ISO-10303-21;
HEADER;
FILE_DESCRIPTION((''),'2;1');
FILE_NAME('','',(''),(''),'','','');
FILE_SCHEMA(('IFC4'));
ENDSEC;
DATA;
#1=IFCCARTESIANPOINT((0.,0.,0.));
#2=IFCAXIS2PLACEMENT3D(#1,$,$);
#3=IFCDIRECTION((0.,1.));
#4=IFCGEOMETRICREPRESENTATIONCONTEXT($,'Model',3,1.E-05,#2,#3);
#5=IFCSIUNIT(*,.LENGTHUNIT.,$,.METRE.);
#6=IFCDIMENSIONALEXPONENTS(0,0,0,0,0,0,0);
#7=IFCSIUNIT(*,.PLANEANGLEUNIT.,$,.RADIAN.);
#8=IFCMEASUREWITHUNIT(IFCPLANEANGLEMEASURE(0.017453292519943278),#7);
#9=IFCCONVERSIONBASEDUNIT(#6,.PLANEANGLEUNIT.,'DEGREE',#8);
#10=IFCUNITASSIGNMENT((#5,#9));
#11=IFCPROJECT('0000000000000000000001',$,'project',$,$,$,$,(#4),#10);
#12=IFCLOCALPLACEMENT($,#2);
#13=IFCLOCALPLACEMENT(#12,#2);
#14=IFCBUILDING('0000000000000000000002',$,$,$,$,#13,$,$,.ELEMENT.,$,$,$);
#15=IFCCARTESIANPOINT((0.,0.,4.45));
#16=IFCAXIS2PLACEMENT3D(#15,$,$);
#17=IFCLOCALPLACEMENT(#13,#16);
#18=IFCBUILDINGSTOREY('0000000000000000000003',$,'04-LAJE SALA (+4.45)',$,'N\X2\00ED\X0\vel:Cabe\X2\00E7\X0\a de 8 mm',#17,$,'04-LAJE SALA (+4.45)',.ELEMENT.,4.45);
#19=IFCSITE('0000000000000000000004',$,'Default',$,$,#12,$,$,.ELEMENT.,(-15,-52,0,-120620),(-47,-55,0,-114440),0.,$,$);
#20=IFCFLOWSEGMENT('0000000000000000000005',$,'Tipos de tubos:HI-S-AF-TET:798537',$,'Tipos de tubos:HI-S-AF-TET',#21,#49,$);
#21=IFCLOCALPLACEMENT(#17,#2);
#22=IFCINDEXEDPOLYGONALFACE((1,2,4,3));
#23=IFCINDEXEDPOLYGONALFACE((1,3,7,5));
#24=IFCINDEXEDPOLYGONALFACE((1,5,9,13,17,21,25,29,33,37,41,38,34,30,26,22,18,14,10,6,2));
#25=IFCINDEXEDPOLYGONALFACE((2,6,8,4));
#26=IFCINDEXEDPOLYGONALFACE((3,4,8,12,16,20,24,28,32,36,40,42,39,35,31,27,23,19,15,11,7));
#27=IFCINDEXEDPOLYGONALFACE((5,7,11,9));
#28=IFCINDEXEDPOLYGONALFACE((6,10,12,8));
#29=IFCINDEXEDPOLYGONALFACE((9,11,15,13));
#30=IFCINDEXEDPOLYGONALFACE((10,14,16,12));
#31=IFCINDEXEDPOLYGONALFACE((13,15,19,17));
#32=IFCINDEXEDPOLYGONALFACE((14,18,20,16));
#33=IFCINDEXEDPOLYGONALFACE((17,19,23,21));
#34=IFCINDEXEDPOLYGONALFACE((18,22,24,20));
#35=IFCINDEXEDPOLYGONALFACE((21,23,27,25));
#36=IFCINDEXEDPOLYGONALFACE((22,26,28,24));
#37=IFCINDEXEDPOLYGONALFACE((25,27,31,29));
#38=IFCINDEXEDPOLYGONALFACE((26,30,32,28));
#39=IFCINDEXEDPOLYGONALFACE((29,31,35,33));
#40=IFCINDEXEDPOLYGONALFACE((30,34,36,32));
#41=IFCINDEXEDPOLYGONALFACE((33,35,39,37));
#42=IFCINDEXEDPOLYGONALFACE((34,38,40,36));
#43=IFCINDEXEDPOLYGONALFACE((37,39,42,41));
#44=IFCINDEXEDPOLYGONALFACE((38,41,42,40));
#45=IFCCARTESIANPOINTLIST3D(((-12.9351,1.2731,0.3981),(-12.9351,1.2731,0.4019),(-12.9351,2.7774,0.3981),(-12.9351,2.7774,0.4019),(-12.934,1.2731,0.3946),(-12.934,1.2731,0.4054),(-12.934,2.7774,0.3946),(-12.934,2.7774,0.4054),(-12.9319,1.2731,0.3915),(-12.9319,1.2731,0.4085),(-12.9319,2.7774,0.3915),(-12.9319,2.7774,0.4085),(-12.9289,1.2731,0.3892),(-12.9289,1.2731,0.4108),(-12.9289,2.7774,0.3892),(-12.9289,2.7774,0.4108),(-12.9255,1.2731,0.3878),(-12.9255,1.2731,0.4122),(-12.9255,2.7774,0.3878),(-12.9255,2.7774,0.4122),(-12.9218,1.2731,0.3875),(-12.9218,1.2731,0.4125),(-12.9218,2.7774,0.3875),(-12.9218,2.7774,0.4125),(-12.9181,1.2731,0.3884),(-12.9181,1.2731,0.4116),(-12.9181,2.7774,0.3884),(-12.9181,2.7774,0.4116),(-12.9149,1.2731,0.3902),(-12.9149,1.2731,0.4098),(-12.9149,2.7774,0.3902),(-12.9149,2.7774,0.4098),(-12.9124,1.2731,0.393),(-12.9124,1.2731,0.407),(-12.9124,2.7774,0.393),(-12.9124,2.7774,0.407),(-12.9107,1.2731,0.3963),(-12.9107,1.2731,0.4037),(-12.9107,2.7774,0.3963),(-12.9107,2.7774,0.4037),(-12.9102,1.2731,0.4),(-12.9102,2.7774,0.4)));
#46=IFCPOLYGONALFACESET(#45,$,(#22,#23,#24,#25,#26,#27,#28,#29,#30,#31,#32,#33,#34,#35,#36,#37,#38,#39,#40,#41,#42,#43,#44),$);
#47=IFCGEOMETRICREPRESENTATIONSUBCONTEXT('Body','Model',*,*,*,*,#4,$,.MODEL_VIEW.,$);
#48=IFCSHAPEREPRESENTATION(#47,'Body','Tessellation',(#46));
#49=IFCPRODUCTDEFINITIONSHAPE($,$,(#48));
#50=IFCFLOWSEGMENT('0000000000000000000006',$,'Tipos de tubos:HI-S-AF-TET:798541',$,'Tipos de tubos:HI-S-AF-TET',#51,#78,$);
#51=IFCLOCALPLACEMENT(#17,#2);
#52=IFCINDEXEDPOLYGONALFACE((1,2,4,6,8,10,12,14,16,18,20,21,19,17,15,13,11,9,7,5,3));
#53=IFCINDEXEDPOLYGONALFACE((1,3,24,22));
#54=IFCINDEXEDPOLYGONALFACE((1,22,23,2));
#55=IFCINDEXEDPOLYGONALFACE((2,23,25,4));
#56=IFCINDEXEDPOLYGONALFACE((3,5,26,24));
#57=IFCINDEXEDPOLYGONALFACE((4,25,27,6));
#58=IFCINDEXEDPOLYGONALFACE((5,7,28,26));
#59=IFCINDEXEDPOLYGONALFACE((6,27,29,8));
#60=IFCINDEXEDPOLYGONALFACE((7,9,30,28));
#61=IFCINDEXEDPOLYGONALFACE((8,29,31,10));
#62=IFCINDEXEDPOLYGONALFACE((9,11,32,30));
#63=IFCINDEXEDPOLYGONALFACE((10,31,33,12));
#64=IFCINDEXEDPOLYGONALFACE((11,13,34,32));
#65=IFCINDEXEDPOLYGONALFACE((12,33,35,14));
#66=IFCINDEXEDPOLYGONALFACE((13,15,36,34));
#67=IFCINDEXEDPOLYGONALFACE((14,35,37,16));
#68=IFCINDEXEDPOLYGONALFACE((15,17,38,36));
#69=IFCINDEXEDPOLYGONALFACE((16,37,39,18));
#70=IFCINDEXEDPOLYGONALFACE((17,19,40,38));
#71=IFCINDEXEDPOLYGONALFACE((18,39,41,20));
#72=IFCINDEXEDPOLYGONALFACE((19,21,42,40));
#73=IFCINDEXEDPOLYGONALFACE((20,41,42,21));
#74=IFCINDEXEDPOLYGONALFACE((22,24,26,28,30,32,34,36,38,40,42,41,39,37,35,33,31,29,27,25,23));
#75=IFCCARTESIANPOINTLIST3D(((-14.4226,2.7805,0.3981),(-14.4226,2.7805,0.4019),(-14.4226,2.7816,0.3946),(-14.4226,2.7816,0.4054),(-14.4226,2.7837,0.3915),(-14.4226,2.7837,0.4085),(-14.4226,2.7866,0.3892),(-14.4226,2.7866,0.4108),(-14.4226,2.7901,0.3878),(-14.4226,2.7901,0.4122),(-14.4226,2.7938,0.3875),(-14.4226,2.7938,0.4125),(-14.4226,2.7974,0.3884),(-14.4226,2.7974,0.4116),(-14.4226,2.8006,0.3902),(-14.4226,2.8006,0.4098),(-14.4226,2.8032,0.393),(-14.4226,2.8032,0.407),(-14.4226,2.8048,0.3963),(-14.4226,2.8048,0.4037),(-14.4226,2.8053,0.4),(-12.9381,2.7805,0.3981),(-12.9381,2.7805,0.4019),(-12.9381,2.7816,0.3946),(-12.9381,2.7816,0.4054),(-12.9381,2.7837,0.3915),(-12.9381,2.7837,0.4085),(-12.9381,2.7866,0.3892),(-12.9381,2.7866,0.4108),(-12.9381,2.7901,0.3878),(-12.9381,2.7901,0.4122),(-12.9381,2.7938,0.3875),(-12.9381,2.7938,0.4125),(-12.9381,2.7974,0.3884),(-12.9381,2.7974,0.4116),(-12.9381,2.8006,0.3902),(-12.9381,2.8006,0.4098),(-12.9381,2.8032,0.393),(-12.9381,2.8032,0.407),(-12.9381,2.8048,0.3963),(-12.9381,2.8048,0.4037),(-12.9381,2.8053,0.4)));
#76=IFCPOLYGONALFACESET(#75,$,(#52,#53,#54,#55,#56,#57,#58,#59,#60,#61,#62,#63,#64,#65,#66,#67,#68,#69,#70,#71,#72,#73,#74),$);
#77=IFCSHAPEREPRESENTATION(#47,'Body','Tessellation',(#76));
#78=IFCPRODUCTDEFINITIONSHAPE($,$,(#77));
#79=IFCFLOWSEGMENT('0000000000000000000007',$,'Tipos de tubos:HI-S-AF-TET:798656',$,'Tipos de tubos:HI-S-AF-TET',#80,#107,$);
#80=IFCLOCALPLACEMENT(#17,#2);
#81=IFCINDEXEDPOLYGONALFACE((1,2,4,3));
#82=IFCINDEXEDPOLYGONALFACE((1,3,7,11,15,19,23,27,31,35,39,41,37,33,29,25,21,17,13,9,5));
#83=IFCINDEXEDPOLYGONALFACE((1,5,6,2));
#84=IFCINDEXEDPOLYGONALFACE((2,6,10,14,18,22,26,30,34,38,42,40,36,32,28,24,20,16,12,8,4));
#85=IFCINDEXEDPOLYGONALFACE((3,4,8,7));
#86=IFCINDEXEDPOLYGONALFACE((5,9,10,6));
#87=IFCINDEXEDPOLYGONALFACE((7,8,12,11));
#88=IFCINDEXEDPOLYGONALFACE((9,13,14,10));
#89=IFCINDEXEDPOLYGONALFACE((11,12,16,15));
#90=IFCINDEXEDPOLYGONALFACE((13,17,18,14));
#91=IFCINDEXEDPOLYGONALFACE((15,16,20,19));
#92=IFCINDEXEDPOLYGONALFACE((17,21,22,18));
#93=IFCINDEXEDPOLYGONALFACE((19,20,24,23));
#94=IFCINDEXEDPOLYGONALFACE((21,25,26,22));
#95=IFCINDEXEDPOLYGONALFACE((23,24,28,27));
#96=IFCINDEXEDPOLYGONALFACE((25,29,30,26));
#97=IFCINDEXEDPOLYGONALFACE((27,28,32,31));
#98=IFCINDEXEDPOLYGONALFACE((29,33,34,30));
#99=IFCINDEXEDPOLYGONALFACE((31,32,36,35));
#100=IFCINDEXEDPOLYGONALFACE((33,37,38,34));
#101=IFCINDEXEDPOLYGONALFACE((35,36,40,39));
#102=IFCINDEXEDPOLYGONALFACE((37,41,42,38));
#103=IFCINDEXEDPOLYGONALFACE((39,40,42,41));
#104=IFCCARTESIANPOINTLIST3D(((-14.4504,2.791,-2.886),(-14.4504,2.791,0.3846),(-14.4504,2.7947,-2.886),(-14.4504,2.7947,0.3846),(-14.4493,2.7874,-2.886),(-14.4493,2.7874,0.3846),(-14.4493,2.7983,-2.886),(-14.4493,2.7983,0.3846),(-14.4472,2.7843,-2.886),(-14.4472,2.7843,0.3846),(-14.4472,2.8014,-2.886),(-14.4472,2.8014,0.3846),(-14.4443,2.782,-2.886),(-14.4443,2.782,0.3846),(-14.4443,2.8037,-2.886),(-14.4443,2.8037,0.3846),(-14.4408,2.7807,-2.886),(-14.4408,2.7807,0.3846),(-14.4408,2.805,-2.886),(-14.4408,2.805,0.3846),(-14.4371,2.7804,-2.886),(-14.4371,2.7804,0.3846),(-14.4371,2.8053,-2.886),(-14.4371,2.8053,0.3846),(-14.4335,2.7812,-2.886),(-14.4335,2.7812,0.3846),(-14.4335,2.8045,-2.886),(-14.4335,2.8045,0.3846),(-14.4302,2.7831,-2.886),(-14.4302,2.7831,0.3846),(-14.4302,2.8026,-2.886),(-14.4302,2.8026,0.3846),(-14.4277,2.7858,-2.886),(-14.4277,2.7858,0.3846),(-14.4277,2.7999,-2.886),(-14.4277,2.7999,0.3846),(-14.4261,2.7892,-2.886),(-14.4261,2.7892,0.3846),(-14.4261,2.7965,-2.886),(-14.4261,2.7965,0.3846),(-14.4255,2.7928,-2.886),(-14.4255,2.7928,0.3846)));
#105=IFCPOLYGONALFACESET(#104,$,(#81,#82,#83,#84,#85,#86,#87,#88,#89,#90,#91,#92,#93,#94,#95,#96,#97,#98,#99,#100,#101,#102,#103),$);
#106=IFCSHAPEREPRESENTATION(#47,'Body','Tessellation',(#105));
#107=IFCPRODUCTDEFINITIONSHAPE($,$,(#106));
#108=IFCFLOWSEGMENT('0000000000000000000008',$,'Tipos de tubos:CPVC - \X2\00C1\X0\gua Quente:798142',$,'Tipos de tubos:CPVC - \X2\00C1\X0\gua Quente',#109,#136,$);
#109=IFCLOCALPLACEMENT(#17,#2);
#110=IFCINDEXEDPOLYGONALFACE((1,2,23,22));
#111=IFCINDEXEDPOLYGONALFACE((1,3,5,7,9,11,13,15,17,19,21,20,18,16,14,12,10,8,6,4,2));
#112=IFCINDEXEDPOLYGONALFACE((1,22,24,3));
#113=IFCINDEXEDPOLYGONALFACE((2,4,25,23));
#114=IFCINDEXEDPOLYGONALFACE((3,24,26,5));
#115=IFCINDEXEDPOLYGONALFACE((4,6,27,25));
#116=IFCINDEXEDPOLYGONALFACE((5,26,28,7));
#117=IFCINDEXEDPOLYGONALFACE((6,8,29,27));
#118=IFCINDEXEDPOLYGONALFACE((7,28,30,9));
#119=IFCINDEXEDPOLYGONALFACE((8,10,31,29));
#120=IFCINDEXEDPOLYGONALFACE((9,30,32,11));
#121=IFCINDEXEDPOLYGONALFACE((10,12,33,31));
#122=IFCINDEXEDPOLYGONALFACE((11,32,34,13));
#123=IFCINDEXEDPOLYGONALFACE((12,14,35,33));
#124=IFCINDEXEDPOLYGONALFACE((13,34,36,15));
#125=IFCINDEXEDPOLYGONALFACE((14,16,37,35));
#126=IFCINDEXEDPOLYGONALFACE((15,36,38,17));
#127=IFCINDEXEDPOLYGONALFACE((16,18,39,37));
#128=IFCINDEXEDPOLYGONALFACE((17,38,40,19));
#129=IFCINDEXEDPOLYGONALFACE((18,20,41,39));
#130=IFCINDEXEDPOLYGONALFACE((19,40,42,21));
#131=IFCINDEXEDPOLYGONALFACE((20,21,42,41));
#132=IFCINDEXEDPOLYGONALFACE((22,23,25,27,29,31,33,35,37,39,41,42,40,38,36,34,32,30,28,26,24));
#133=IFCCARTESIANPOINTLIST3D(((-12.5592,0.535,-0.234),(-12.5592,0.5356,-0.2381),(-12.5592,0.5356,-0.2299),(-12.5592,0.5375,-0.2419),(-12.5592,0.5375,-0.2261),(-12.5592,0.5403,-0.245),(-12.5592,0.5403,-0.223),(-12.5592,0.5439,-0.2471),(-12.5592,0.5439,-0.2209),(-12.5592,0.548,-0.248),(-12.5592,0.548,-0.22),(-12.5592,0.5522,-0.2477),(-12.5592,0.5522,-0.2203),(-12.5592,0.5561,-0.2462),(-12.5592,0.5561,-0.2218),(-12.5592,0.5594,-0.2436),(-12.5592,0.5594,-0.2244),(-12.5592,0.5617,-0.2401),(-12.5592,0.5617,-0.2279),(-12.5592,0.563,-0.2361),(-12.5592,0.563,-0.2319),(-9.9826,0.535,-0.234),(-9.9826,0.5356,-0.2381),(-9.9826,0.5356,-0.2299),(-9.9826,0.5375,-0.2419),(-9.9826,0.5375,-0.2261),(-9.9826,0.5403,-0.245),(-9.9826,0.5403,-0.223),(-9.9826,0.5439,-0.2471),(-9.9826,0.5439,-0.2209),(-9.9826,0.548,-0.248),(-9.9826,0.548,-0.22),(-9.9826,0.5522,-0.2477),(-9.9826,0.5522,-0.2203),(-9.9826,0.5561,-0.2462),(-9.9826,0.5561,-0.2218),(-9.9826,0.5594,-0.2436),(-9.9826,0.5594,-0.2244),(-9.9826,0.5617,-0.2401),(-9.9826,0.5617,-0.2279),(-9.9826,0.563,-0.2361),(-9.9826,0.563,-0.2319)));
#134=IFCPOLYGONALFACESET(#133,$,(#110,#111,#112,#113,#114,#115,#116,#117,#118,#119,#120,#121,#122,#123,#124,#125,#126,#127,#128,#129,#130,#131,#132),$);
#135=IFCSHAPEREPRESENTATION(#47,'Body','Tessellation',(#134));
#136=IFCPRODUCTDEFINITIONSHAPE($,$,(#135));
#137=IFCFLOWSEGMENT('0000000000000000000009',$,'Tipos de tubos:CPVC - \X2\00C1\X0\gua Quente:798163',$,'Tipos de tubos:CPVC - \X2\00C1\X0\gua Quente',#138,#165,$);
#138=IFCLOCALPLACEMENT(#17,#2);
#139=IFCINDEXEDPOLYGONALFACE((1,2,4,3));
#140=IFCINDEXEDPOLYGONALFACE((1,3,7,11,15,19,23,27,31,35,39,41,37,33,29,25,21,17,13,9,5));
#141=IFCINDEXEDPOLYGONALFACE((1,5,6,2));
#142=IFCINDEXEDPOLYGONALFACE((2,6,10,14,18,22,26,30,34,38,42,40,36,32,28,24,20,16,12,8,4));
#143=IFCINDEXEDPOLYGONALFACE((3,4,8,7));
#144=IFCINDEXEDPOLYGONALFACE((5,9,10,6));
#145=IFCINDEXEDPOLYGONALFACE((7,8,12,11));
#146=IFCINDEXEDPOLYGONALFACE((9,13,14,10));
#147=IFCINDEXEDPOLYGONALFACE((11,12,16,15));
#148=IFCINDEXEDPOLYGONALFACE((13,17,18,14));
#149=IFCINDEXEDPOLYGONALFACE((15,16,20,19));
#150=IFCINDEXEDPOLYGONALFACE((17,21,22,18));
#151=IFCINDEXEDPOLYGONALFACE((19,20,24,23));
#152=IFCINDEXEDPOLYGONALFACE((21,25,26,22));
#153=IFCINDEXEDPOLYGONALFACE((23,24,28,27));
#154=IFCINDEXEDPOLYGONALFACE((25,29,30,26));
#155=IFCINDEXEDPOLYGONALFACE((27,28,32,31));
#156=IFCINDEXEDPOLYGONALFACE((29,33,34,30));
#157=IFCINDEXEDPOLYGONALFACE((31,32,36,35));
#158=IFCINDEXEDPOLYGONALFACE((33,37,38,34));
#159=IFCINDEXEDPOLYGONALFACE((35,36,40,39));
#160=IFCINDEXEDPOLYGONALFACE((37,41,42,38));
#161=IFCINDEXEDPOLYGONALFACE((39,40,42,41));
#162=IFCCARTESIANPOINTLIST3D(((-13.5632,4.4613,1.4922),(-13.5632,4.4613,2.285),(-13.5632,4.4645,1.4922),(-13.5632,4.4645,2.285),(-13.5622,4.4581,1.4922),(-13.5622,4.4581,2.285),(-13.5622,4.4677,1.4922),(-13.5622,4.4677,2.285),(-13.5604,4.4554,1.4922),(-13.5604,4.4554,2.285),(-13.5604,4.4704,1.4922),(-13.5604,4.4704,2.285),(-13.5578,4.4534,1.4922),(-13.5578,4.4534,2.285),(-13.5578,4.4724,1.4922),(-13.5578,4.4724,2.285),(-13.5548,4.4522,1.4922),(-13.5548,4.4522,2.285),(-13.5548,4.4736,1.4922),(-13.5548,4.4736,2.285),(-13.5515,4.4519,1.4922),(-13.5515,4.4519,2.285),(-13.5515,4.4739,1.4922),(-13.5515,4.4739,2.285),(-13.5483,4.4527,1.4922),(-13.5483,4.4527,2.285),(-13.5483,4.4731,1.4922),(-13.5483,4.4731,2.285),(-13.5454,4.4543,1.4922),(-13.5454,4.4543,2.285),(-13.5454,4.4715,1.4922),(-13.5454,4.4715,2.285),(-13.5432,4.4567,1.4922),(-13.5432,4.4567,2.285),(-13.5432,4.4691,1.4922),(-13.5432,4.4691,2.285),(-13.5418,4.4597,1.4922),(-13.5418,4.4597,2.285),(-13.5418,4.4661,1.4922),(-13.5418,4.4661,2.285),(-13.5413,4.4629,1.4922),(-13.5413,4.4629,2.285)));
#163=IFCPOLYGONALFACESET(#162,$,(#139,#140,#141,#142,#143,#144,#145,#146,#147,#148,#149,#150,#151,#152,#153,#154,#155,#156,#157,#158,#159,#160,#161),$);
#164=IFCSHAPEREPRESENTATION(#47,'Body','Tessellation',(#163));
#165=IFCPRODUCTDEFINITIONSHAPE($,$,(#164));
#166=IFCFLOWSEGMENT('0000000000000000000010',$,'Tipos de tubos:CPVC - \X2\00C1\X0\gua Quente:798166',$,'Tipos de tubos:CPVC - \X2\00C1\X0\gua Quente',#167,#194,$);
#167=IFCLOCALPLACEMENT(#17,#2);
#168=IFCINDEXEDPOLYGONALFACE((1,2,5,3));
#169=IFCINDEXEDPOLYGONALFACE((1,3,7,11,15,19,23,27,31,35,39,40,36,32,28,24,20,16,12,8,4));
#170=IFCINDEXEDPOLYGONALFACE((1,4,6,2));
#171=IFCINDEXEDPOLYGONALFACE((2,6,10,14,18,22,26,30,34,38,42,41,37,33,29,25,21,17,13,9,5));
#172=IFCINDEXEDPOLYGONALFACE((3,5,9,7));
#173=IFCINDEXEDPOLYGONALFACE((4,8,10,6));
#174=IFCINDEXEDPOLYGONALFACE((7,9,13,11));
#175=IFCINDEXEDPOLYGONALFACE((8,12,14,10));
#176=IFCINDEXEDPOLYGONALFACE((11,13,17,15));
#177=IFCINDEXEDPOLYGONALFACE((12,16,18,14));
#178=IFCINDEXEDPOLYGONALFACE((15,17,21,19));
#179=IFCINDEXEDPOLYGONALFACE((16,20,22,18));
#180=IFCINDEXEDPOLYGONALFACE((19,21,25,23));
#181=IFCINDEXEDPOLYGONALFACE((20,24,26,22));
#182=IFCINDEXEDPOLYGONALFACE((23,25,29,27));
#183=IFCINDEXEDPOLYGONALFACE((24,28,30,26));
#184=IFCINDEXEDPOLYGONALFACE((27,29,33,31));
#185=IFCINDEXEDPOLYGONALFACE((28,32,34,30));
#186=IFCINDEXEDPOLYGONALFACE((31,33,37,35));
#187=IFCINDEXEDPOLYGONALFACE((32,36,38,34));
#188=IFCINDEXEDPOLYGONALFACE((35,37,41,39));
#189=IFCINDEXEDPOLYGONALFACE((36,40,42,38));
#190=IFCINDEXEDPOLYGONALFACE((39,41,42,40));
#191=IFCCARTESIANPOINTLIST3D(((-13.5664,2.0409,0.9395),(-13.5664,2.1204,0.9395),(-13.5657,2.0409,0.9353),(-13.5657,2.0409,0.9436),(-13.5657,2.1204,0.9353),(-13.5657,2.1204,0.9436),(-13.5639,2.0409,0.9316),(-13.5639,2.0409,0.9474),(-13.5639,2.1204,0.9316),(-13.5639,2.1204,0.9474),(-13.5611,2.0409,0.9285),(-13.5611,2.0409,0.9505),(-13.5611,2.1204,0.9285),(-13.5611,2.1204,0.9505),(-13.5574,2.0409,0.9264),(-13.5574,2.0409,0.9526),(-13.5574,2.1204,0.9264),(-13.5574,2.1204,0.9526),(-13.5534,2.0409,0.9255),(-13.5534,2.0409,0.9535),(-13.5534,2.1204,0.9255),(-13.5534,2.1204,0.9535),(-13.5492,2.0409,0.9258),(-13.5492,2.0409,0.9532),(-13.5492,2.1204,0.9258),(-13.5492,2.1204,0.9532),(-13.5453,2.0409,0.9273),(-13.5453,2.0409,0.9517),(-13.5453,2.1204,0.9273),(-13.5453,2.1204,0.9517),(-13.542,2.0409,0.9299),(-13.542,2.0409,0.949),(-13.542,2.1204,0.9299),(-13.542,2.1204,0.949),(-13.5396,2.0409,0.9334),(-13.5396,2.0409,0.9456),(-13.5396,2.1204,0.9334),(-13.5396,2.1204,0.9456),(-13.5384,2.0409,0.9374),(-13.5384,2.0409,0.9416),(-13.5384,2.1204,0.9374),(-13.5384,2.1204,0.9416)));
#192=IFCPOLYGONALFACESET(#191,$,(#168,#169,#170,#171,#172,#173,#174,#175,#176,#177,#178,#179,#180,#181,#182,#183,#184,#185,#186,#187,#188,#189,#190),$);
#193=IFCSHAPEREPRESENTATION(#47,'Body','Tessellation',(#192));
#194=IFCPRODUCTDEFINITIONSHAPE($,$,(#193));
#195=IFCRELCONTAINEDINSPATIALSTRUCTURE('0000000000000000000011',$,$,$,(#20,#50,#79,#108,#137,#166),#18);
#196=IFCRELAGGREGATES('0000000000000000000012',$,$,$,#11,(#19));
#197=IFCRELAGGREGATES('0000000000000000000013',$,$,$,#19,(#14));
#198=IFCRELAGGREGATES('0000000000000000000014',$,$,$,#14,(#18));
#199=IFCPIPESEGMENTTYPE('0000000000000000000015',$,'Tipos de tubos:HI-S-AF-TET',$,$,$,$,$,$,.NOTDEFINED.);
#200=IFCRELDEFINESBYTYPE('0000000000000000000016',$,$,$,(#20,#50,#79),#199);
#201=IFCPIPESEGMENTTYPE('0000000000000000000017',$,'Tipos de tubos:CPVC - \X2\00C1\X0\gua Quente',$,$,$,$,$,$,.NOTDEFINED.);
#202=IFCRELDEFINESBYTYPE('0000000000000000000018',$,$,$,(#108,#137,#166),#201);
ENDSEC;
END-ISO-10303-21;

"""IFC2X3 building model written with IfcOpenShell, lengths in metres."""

from ifc_helpers import new_model, entity, si_unit, converted_unit, direction, frame, frame_2d, origin, origin_2d_with_axis, place, context, subcontext, project, spatial, circle, extrude, type_object, element, save


model = new_model("IFC2X3")

# Units and contexts
model_context = context("Model", 3, precision=1e-05, world=origin(), true_north=direction((0.0, 1.0)))
body_context = subcontext(model_context, "Body", "Model", "MODEL_VIEW")
ifc_project = project(units=[si_unit("LENGTHUNIT", "METRE"), converted_unit("PLANEANGLEUNIT", "DEGREE", entity("IfcPlaneAngleMeasure", 0.017453292519943278), si_unit("PLANEANGLEUNIT", "RADIAN"), dimensions=[0, 0, 0, 0, 0, 0, 0])], contexts=[model_context])

# Site, building, storey
site_placement = place(None, origin())
site = spatial("IfcSite", under=ifc_project, at=site_placement, Name="Default", CompositionType="ELEMENT", RefLatitude=(-15, -52, 0, -120620), RefLongitude=(-47, -55, 0, -114440), RefElevation=0.0)
building_placement = place(site_placement, origin())
building = spatial("IfcBuilding", under=site, at=building_placement, CompositionType="ELEMENT")
storey_placement = place(building_placement, frame((0.0, 0.0, 4.45)))
storey = spatial("IfcBuildingStorey", under=building, at=storey_placement, Name="04-LAJE SALA (+4.45)", ObjectType="Nível:Cabeça de 8 mm", LongName="04-LAJE SALA (+4.45)", CompositionType="ELEMENT", Elevation=4.45)

# Flow segments
pipe_segment_type_1 = type_object("IfcPipeSegmentType", Name="Tipos de tubos:HI-S-AF-TET", PredefinedType="NOTDEFINED")
flow_segment_1_placement = place(storey_placement, origin())
element("IfcFlowSegment", 1, at=flow_segment_1_placement, inside=storey, type_object=pipe_segment_type_1, Name="Tipos de tubos:HI-S-AF-TET:798537", ObjectType="Tipos de tubos:HI-S-AF-TET", context=body_context, shape_type="SweptSolid", body=[
    extrude(circle(Radius=0.0125, at=frame_2d((0.0, 0.0), x_axis=(1.0, 0.0))), frame((-12.9227, 1.2731, 0.4), z_axis=(0.0, 1.0, 0.0), x_axis=(1.0, 0.0, 0.0)), (0.0, 0.0, 1.0), 1.5044),
])
flow_segment_2_placement = place(storey_placement, origin())
element("IfcFlowSegment", 2, at=flow_segment_2_placement, inside=storey, type_object=pipe_segment_type_1, Name="Tipos de tubos:HI-S-AF-TET:798541", ObjectType="Tipos de tubos:HI-S-AF-TET", context=body_context, shape_type="SweptSolid", body=[
    extrude(circle(Radius=0.0125, at=origin_2d_with_axis()), frame((-14.4226, 2.7928, 0.4), z_axis=(1.0, 0.0, 0.0), x_axis=(0.0, 1.0, 0.0)), (0.0, 0.0, 1.0), 1.4845),
])
flow_segment_3_placement = place(storey_placement, origin())
element("IfcFlowSegment", 3, at=flow_segment_3_placement, inside=storey, type_object=pipe_segment_type_1, Name="Tipos de tubos:HI-S-AF-TET:798656", ObjectType="Tipos de tubos:HI-S-AF-TET", context=body_context, shape_type="SweptSolid", body=[
    extrude(circle(Radius=0.0125, at=origin_2d_with_axis()), frame((-14.438, 2.7928, -2.886)), (0.0, 0.0, 1.0), 3.2706),
])
pipe_segment_type_2 = type_object("IfcPipeSegmentType", Name="Tipos de tubos:CPVC - Água Quente", PredefinedType="NOTDEFINED")
flow_segment_4_placement = place(storey_placement, origin())
element("IfcFlowSegment", 4, at=flow_segment_4_placement, inside=storey, type_object=pipe_segment_type_2, Name="Tipos de tubos:CPVC - Água Quente:798142", ObjectType="Tipos de tubos:CPVC - Água Quente", context=body_context, shape_type="SweptSolid", body=[
    extrude(circle(Radius=0.0141, at=origin_2d_with_axis()), frame((-12.5592, 0.5491, -0.234), z_axis=(1.0, 0.0, 0.0), x_axis=(0.0, -1.0, 0.0)), (0.0, 0.0, 1.0), 2.5765),
])
flow_segment_5_placement = place(storey_placement, origin())
element("IfcFlowSegment", 5, at=flow_segment_5_placement, inside=storey, type_object=pipe_segment_type_2, Name="Tipos de tubos:CPVC - Água Quente:798163", ObjectType="Tipos de tubos:CPVC - Água Quente", context=body_context, shape_type="SweptSolid", body=[
    extrude(circle(Radius=0.011, at=origin_2d_with_axis()), frame((-13.5523, 4.4629, 1.4922)), (0.0, 0.0, 1.0), 0.7928),
])
flow_segment_6_placement = place(storey_placement, origin())
element("IfcFlowSegment", 6, at=flow_segment_6_placement, inside=storey, type_object=pipe_segment_type_2, Name="Tipos de tubos:CPVC - Água Quente:798166", ObjectType="Tipos de tubos:CPVC - Água Quente", context=body_context, shape_type="SweptSolid", body=[
    extrude(circle(Radius=0.0141, at=frame_2d((0.0, 0.0), x_axis=(1.0, 0.0))), frame((-13.5523, 2.0409, 0.9395), z_axis=(0.0, 1.0, 0.0), x_axis=(-1.0, 0.0, 0.0)), (0.0, 0.0, 1.0), 0.0795),
])

save(model, "model.ifc")
